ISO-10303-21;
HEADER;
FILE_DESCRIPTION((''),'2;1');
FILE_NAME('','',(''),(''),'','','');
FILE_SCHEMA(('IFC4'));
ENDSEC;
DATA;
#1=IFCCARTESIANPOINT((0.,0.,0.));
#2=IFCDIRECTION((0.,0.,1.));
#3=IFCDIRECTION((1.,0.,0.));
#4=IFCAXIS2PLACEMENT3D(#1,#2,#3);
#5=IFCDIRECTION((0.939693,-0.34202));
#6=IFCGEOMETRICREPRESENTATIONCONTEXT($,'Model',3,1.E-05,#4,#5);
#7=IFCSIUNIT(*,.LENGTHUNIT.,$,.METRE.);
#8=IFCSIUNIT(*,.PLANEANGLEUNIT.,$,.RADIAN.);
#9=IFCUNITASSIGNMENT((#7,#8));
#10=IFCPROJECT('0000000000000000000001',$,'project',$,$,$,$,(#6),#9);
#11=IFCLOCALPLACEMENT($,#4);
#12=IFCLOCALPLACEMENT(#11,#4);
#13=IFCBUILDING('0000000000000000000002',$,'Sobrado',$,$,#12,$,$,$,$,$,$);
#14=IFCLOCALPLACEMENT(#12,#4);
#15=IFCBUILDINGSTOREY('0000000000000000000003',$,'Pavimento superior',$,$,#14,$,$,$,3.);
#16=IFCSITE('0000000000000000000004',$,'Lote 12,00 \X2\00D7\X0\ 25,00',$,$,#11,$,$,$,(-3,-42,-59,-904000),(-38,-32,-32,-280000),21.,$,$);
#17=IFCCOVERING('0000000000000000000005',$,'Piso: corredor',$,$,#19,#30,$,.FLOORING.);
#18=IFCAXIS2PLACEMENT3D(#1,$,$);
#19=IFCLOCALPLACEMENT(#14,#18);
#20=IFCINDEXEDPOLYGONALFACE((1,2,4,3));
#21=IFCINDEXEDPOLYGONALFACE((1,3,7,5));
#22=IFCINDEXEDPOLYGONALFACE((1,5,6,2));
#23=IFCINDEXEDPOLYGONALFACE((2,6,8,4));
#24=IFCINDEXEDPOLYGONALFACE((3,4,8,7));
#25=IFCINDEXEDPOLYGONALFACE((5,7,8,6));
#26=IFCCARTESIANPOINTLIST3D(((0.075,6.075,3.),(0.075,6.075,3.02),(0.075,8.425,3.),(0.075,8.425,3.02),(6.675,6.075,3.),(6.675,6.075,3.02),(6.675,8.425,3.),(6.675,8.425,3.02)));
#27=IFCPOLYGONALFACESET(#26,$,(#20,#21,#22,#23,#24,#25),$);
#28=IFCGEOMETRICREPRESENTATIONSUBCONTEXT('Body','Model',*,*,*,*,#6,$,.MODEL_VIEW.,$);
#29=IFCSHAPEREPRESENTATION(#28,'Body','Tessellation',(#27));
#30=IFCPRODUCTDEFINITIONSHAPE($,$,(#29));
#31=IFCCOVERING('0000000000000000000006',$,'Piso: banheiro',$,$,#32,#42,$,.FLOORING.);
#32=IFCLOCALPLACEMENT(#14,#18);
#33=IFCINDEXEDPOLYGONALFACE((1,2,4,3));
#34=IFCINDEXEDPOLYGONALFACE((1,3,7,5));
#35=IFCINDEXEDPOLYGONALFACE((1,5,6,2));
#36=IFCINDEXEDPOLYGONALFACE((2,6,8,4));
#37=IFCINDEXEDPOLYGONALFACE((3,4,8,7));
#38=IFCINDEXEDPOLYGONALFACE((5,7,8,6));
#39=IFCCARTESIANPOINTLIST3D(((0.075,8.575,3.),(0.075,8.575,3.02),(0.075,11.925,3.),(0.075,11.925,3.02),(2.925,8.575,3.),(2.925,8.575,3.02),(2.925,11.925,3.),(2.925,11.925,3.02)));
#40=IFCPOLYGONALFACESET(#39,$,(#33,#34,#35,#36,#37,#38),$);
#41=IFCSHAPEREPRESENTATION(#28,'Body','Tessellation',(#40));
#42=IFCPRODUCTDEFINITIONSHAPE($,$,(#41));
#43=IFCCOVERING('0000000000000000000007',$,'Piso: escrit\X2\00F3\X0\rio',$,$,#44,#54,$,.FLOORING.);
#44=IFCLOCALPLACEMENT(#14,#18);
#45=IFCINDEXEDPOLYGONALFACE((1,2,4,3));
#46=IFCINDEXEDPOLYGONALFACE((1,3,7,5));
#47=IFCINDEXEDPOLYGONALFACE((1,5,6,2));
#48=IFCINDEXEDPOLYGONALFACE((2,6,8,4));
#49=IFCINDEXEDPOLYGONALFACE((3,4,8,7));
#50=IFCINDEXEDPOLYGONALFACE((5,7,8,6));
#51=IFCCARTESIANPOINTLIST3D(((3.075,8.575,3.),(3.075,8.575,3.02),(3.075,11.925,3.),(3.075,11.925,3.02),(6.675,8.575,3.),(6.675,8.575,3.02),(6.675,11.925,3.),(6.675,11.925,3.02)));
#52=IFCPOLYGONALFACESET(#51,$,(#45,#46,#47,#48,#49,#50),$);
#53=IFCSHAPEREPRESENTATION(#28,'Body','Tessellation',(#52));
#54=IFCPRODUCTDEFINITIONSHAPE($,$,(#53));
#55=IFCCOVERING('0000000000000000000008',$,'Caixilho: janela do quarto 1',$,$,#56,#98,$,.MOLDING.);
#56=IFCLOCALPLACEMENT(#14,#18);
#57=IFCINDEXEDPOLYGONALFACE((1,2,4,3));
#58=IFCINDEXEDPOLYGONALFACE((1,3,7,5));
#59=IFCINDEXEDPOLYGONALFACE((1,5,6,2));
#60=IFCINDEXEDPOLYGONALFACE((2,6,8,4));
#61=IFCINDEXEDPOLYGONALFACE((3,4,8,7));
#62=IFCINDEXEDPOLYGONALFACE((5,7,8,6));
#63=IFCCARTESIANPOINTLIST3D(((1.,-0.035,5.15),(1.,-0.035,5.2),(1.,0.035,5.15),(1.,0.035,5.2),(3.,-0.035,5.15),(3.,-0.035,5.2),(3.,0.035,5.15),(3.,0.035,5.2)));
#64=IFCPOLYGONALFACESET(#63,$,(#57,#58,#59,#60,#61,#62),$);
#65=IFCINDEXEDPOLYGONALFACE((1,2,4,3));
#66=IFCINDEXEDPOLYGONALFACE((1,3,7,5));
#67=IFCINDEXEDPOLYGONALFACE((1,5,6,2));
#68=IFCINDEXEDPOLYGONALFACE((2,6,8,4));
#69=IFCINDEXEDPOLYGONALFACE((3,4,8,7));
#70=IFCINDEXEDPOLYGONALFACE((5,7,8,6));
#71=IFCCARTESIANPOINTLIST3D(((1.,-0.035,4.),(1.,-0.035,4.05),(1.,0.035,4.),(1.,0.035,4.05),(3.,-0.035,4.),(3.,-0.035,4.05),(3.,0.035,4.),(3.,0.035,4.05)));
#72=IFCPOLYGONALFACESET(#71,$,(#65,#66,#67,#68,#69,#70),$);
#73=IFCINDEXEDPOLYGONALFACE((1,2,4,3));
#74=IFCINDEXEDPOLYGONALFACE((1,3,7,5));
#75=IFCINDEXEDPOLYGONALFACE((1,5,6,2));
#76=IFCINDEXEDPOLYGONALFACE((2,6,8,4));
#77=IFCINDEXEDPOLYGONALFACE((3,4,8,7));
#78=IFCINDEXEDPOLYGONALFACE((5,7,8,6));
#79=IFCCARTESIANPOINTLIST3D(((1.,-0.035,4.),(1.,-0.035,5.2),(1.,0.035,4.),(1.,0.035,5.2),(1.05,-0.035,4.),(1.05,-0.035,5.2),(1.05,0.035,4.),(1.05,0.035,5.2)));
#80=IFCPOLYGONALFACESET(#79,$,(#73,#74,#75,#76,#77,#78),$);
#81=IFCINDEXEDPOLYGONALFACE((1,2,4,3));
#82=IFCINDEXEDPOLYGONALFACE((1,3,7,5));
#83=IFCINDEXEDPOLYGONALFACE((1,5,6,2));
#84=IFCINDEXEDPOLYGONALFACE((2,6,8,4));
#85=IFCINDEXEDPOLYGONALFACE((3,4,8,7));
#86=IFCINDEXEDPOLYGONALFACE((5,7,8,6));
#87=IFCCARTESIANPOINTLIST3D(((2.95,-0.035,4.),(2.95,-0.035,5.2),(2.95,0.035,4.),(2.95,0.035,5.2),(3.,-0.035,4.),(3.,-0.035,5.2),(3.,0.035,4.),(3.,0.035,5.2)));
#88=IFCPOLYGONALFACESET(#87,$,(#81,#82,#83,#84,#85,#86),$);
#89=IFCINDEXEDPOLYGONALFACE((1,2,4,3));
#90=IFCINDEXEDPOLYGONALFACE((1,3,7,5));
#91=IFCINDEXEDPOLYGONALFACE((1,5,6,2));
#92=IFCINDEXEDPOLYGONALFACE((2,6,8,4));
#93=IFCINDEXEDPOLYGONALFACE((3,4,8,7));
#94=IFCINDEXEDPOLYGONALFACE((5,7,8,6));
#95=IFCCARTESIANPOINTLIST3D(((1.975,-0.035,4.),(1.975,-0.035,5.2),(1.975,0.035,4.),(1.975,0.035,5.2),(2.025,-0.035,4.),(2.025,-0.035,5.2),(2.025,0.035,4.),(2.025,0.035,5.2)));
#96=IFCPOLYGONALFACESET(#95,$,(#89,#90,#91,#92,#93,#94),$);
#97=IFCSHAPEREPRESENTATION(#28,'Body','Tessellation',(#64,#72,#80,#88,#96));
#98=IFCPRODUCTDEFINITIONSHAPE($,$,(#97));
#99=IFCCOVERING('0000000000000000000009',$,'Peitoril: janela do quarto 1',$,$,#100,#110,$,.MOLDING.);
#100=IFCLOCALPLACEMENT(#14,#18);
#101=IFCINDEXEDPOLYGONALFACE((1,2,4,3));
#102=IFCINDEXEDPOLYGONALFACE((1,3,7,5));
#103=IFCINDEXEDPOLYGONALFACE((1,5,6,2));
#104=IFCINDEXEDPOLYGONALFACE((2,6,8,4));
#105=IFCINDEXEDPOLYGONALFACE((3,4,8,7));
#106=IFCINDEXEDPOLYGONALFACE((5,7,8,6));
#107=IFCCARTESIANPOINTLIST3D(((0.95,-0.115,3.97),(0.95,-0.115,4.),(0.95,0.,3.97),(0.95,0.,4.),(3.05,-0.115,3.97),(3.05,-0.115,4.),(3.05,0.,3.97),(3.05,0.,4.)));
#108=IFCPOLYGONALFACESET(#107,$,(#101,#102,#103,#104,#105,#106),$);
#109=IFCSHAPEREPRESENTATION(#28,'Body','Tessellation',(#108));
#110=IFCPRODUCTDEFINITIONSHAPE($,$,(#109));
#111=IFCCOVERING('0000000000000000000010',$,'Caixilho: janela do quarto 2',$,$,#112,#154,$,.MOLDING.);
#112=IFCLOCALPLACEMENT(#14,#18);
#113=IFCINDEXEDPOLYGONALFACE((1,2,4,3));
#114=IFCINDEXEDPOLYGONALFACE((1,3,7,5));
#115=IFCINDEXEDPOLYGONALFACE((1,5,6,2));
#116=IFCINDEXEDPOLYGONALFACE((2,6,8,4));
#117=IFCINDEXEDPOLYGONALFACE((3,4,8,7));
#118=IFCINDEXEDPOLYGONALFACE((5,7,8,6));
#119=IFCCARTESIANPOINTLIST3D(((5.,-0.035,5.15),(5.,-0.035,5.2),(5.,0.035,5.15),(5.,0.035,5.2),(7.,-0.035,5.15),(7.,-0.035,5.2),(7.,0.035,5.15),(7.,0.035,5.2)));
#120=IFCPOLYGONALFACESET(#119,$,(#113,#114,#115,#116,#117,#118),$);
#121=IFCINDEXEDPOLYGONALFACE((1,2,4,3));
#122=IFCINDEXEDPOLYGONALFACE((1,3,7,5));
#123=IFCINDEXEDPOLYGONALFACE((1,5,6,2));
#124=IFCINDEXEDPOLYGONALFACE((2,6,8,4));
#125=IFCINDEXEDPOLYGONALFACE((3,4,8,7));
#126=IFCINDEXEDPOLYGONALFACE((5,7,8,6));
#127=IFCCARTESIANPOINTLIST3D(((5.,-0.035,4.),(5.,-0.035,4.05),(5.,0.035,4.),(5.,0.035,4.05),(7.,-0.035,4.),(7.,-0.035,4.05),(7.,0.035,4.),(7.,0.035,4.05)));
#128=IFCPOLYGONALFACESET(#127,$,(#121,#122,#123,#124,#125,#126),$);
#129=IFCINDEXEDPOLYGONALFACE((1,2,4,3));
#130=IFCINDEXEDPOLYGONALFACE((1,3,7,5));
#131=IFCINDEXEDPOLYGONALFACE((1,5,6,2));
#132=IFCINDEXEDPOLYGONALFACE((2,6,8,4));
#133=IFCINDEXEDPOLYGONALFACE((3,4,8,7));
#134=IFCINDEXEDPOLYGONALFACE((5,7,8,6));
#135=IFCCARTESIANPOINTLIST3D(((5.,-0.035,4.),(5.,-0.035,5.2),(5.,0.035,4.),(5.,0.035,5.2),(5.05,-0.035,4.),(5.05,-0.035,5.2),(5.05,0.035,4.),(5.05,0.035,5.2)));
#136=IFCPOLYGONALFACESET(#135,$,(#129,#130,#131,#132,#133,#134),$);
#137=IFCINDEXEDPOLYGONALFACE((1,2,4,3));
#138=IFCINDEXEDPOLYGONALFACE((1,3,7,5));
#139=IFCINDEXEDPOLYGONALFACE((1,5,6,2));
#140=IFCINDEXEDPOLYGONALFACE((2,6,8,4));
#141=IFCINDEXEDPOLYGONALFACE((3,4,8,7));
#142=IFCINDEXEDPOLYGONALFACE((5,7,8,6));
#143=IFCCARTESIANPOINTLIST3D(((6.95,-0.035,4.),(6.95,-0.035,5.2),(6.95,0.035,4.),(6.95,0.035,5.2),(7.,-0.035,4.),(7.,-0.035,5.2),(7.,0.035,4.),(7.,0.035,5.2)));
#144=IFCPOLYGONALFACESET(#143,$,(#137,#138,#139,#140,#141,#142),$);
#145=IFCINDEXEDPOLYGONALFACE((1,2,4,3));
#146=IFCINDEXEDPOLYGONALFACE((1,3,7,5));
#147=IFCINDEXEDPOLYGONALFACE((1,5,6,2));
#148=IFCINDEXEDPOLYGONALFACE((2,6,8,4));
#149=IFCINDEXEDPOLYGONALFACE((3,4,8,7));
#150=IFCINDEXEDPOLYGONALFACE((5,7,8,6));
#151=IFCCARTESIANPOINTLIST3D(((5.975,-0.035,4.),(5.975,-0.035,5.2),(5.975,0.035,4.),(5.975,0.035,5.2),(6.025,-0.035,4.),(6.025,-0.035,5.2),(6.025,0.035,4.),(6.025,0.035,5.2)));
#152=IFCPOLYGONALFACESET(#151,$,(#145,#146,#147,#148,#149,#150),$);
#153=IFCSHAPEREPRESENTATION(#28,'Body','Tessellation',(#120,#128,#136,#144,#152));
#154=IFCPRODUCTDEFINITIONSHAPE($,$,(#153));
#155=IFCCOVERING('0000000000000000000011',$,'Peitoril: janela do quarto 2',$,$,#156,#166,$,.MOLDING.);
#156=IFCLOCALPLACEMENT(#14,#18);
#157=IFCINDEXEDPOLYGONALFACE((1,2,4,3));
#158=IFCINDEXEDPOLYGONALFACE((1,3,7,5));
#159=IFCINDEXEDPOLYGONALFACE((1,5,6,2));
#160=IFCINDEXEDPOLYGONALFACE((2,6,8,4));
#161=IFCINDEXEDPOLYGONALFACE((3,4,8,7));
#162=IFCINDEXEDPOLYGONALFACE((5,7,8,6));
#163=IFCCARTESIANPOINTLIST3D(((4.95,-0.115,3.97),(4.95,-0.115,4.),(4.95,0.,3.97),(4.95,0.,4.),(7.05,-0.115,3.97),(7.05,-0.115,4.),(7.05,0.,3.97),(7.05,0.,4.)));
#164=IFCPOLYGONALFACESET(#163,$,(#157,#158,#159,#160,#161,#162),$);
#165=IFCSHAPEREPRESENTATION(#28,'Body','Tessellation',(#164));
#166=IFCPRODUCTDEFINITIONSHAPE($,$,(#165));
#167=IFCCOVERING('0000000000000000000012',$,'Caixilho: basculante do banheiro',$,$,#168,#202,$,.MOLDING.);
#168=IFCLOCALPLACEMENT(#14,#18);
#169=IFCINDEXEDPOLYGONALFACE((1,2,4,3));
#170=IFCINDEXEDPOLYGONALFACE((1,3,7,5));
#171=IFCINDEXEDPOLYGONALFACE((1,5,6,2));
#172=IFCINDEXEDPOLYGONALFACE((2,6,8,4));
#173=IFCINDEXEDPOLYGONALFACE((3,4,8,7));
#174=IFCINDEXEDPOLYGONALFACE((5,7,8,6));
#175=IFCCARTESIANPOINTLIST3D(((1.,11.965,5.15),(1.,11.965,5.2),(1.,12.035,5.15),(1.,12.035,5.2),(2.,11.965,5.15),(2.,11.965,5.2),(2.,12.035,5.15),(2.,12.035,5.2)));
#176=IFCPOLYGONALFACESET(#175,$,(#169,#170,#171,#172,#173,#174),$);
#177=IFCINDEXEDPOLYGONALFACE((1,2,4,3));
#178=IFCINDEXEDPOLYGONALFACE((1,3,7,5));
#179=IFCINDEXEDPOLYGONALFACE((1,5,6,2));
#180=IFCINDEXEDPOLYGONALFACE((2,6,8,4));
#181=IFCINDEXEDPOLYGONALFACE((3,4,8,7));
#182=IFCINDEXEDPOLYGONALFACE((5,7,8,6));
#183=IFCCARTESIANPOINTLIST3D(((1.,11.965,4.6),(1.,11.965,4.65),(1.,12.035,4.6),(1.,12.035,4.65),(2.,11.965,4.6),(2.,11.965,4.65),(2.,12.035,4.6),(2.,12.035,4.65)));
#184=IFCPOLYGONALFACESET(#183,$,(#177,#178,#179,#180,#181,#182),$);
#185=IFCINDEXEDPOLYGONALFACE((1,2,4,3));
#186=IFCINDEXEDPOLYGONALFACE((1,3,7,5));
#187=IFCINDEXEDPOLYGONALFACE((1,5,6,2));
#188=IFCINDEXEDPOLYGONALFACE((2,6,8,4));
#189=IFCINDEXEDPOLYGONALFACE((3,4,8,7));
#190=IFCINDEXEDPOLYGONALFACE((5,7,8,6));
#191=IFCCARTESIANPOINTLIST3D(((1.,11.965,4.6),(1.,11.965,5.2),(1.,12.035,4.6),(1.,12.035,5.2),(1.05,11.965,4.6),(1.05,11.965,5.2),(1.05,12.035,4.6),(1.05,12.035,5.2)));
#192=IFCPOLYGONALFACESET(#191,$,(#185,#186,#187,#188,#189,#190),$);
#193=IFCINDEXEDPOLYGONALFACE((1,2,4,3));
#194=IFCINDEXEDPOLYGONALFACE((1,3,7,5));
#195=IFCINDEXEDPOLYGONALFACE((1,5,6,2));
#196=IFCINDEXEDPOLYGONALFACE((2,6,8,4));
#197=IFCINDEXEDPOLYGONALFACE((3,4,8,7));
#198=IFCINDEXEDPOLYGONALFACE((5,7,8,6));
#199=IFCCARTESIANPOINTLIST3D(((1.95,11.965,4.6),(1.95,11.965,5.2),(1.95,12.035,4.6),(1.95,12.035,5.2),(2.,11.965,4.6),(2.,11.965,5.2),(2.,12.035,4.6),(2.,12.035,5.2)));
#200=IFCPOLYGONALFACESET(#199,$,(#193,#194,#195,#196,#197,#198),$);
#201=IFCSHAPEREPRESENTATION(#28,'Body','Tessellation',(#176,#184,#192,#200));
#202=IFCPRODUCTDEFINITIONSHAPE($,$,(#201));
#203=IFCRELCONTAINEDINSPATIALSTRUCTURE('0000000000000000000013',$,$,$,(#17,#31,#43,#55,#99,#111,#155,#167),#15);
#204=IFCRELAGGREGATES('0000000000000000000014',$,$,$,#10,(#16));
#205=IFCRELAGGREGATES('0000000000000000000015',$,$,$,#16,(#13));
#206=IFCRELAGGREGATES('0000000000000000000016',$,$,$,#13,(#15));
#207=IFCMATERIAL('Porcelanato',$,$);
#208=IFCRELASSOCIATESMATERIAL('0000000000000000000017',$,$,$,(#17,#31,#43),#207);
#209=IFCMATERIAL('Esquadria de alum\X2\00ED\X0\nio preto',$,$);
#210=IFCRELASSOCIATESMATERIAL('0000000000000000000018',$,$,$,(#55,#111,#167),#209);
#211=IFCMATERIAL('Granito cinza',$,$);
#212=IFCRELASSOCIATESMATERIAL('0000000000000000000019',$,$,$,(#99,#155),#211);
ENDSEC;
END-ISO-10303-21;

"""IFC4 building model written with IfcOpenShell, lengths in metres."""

from ifc_helpers import new_model, si_unit, direction, frame, origin_with_axes, place, context, subcontext, project, spatial, line, indexed_curve, outline, extrude, material, element, save


model = new_model("IFC4")

# Units and contexts
model_context = context("Model", 3, precision=1e-05, world=origin_with_axes(), true_north=direction((0.939693, -0.34202)))
body_context = subcontext(model_context, "Body", "Model", "MODEL_VIEW")
ifc_project = project(units=[si_unit("LENGTHUNIT", "METRE"), si_unit("PLANEANGLEUNIT", "RADIAN")], contexts=[model_context])

# Site, building, storey
site_placement = place(None, origin_with_axes())
site = spatial("IfcSite", under=ifc_project, at=site_placement, Name="Lote 12,00 × 25,00", RefLatitude=(-3, -42, -59, -904000), RefLongitude=(-38, -32, -32, -280000), RefElevation=21.0)
building_placement = place(site_placement, origin_with_axes())
building = spatial("IfcBuilding", under=site, at=building_placement, Name="Sobrado")
storey_placement = place(building_placement, origin_with_axes())
storey = spatial("IfcBuildingStorey", under=building, at=storey_placement, Name="Pavimento superior", Elevation=3.0)

# Coverings
ifc_material_1 = material(Name="Porcelanato")
covering_1_placement = place(storey_placement, origin_with_axes())
element("IfcCovering", 1, at=covering_1_placement, inside=storey, material=ifc_material_1, Name="Piso: corredor", PredefinedType="FLOORING", context=body_context, shape_type="SweptSolid", body=[
    extrude(outline(indexed_curve([(0.075, 6.075), (6.675, 6.075), (6.675, 8.425), (0.075, 8.425)], segments=[line(1, 2, 3, 4, 1)])), frame((0.0, 0.0, 3.0), z_axis=(0.0, 0.0, 1.0), x_axis=(1.0, 0.0, 0.0)), (0.0, 0.0, 1.0), 0.02),
])
covering_2_placement = place(storey_placement, origin_with_axes())
element("IfcCovering", 2, at=covering_2_placement, inside=storey, material=ifc_material_1, Name="Piso: banheiro", PredefinedType="FLOORING", context=body_context, shape_type="SweptSolid", body=[
    extrude(outline(indexed_curve([(0.075, 8.575), (2.925, 8.575), (2.925, 11.925), (0.075, 11.925)], segments=[line(1, 2, 3, 4, 1)])), frame((0.0, 0.0, 3.0), z_axis=(0.0, 0.0, 1.0), x_axis=(1.0, 0.0, 0.0)), (0.0, 0.0, 1.0), 0.02),
])
covering_3_placement = place(storey_placement, origin_with_axes())
element("IfcCovering", 3, at=covering_3_placement, inside=storey, material=ifc_material_1, Name="Piso: escritório", PredefinedType="FLOORING", context=body_context, shape_type="SweptSolid", body=[
    extrude(outline(indexed_curve([(3.075, 8.575), (6.675, 8.575), (6.675, 11.925), (3.075, 11.925)], segments=[line(1, 2, 3, 4, 1)])), frame((0.0, 0.0, 3.0), z_axis=(0.0, 0.0, 1.0), x_axis=(1.0, 0.0, 0.0)), (0.0, 0.0, 1.0), 0.02),
])
ifc_material_2 = material(Name="Esquadria de alumínio preto")
covering_4_placement = place(storey_placement, origin_with_axes())
element("IfcCovering", 4, at=covering_4_placement, inside=storey, material=ifc_material_2, Name="Caixilho: janela do quarto 1", PredefinedType="MOLDING", context=body_context, shape_type="SweptSolid", body=[
    extrude(outline(indexed_curve([(1.0, -0.035), (3.0, -0.035), (3.0, 0.035), (1.0, 0.035)], segments=[line(1, 2, 3, 4, 1)])), frame((0.0, 0.0, 5.15), z_axis=(0.0, 0.0, 1.0), x_axis=(1.0, 0.0, 0.0)), (0.0, 0.0, 1.0), 0.05),
    extrude(outline(indexed_curve([(1.0, -0.035), (3.0, -0.035), (3.0, 0.035), (1.0, 0.035)], segments=[line(1, 2, 3, 4, 1)])), frame((0.0, 0.0, 4.0), z_axis=(0.0, 0.0, 1.0), x_axis=(1.0, 0.0, 0.0)), (0.0, 0.0, 1.0), 0.05),
    extrude(outline(indexed_curve([(1.0, -0.035), (1.05, -0.035), (1.05, 0.035), (1.0, 0.035)], segments=[line(1, 2, 3, 4, 1)])), frame((0.0, 0.0, 4.0), z_axis=(0.0, 0.0, 1.0), x_axis=(1.0, 0.0, 0.0)), (0.0, 0.0, 1.0), 1.2),
    extrude(outline(indexed_curve([(2.95, -0.035), (3.0, -0.035), (3.0, 0.035), (2.95, 0.035)], segments=[line(1, 2, 3, 4, 1)])), frame((0.0, 0.0, 4.0), z_axis=(0.0, 0.0, 1.0), x_axis=(1.0, 0.0, 0.0)), (0.0, 0.0, 1.0), 1.2),
    extrude(outline(indexed_curve([(1.975, -0.035), (2.025, -0.035), (2.025, 0.035), (1.975, 0.035)], segments=[line(1, 2, 3, 4, 1)])), frame((0.0, 0.0, 4.0), z_axis=(0.0, 0.0, 1.0), x_axis=(1.0, 0.0, 0.0)), (0.0, 0.0, 1.0), 1.2),
])
ifc_material_3 = material(Name="Granito cinza")
covering_5_placement = place(storey_placement, origin_with_axes())
element("IfcCovering", 5, at=covering_5_placement, inside=storey, material=ifc_material_3, Name="Peitoril: janela do quarto 1", PredefinedType="MOLDING", context=body_context, shape_type="SweptSolid", body=[
    extrude(outline(indexed_curve([(0.95, -0.115), (3.05, -0.115), (3.05, 0.0), (0.95, 0.0)], segments=[line(1, 2, 3, 4, 1)])), frame((0.0, 0.0, 3.97), z_axis=(0.0, 0.0, 1.0), x_axis=(1.0, 0.0, 0.0)), (0.0, 0.0, 1.0), 0.03),
])
covering_6_placement = place(storey_placement, origin_with_axes())
element("IfcCovering", 6, at=covering_6_placement, inside=storey, material=ifc_material_2, Name="Caixilho: janela do quarto 2", PredefinedType="MOLDING", context=body_context, shape_type="SweptSolid", body=[
    extrude(outline(indexed_curve([(5.0, -0.035), (7.0, -0.035), (7.0, 0.035), (5.0, 0.035)], segments=[line(1, 2, 3, 4, 1)])), frame((0.0, 0.0, 5.15), z_axis=(0.0, 0.0, 1.0), x_axis=(1.0, 0.0, 0.0)), (0.0, 0.0, 1.0), 0.05),
    extrude(outline(indexed_curve([(5.0, -0.035), (7.0, -0.035), (7.0, 0.035), (5.0, 0.035)], segments=[line(1, 2, 3, 4, 1)])), frame((0.0, 0.0, 4.0), z_axis=(0.0, 0.0, 1.0), x_axis=(1.0, 0.0, 0.0)), (0.0, 0.0, 1.0), 0.05),
    extrude(outline(indexed_curve([(5.0, -0.035), (5.05, -0.035), (5.05, 0.035), (5.0, 0.035)], segments=[line(1, 2, 3, 4, 1)])), frame((0.0, 0.0, 4.0), z_axis=(0.0, 0.0, 1.0), x_axis=(1.0, 0.0, 0.0)), (0.0, 0.0, 1.0), 1.2),
    extrude(outline(indexed_curve([(6.95, -0.035), (7.0, -0.035), (7.0, 0.035), (6.95, 0.035)], segments=[line(1, 2, 3, 4, 1)])), frame((0.0, 0.0, 4.0), z_axis=(0.0, 0.0, 1.0), x_axis=(1.0, 0.0, 0.0)), (0.0, 0.0, 1.0), 1.2),
    extrude(outline(indexed_curve([(5.975, -0.035), (6.025, -0.035), (6.025, 0.035), (5.975, 0.035)], segments=[line(1, 2, 3, 4, 1)])), frame((0.0, 0.0, 4.0), z_axis=(0.0, 0.0, 1.0), x_axis=(1.0, 0.0, 0.0)), (0.0, 0.0, 1.0), 1.2),
])
covering_7_placement = place(storey_placement, origin_with_axes())
element("IfcCovering", 7, at=covering_7_placement, inside=storey, material=ifc_material_3, Name="Peitoril: janela do quarto 2", PredefinedType="MOLDING", context=body_context, shape_type="SweptSolid", body=[
    extrude(outline(indexed_curve([(4.95, -0.115), (7.05, -0.115), (7.05, 0.0), (4.95, 0.0)], segments=[line(1, 2, 3, 4, 1)])), frame((0.0, 0.0, 3.97), z_axis=(0.0, 0.0, 1.0), x_axis=(1.0, 0.0, 0.0)), (0.0, 0.0, 1.0), 0.03),
])
covering_8_placement = place(storey_placement, origin_with_axes())
element("IfcCovering", 8, at=covering_8_placement, inside=storey, material=ifc_material_2, Name="Caixilho: basculante do banheiro", PredefinedType="MOLDING", context=body_context, shape_type="SweptSolid", body=[
    extrude(outline(indexed_curve([(1.0, 11.965), (2.0, 11.965), (2.0, 12.035), (1.0, 12.035)], segments=[line(1, 2, 3, 4, 1)])), frame((0.0, 0.0, 5.15), z_axis=(0.0, 0.0, 1.0), x_axis=(1.0, 0.0, 0.0)), (0.0, 0.0, 1.0), 0.05),
    extrude(outline(indexed_curve([(1.0, 11.965), (2.0, 11.965), (2.0, 12.035), (1.0, 12.035)], segments=[line(1, 2, 3, 4, 1)])), frame((0.0, 0.0, 4.6), z_axis=(0.0, 0.0, 1.0), x_axis=(1.0, 0.0, 0.0)), (0.0, 0.0, 1.0), 0.05),
    extrude(outline(indexed_curve([(1.0, 11.965), (1.05, 11.965), (1.05, 12.035), (1.0, 12.035)], segments=[line(1, 2, 3, 4, 1)])), frame((0.0, 0.0, 4.6), z_axis=(0.0, 0.0, 1.0), x_axis=(1.0, 0.0, 0.0)), (0.0, 0.0, 1.0), 0.6),
    extrude(outline(indexed_curve([(1.95, 11.965), (2.0, 11.965), (2.0, 12.035), (1.95, 12.035)], segments=[line(1, 2, 3, 4, 1)])), frame((0.0, 0.0, 4.6), z_axis=(0.0, 0.0, 1.0), x_axis=(1.0, 0.0, 0.0)), (0.0, 0.0, 1.0), 0.6),
])

save(model, "model.ifc")
